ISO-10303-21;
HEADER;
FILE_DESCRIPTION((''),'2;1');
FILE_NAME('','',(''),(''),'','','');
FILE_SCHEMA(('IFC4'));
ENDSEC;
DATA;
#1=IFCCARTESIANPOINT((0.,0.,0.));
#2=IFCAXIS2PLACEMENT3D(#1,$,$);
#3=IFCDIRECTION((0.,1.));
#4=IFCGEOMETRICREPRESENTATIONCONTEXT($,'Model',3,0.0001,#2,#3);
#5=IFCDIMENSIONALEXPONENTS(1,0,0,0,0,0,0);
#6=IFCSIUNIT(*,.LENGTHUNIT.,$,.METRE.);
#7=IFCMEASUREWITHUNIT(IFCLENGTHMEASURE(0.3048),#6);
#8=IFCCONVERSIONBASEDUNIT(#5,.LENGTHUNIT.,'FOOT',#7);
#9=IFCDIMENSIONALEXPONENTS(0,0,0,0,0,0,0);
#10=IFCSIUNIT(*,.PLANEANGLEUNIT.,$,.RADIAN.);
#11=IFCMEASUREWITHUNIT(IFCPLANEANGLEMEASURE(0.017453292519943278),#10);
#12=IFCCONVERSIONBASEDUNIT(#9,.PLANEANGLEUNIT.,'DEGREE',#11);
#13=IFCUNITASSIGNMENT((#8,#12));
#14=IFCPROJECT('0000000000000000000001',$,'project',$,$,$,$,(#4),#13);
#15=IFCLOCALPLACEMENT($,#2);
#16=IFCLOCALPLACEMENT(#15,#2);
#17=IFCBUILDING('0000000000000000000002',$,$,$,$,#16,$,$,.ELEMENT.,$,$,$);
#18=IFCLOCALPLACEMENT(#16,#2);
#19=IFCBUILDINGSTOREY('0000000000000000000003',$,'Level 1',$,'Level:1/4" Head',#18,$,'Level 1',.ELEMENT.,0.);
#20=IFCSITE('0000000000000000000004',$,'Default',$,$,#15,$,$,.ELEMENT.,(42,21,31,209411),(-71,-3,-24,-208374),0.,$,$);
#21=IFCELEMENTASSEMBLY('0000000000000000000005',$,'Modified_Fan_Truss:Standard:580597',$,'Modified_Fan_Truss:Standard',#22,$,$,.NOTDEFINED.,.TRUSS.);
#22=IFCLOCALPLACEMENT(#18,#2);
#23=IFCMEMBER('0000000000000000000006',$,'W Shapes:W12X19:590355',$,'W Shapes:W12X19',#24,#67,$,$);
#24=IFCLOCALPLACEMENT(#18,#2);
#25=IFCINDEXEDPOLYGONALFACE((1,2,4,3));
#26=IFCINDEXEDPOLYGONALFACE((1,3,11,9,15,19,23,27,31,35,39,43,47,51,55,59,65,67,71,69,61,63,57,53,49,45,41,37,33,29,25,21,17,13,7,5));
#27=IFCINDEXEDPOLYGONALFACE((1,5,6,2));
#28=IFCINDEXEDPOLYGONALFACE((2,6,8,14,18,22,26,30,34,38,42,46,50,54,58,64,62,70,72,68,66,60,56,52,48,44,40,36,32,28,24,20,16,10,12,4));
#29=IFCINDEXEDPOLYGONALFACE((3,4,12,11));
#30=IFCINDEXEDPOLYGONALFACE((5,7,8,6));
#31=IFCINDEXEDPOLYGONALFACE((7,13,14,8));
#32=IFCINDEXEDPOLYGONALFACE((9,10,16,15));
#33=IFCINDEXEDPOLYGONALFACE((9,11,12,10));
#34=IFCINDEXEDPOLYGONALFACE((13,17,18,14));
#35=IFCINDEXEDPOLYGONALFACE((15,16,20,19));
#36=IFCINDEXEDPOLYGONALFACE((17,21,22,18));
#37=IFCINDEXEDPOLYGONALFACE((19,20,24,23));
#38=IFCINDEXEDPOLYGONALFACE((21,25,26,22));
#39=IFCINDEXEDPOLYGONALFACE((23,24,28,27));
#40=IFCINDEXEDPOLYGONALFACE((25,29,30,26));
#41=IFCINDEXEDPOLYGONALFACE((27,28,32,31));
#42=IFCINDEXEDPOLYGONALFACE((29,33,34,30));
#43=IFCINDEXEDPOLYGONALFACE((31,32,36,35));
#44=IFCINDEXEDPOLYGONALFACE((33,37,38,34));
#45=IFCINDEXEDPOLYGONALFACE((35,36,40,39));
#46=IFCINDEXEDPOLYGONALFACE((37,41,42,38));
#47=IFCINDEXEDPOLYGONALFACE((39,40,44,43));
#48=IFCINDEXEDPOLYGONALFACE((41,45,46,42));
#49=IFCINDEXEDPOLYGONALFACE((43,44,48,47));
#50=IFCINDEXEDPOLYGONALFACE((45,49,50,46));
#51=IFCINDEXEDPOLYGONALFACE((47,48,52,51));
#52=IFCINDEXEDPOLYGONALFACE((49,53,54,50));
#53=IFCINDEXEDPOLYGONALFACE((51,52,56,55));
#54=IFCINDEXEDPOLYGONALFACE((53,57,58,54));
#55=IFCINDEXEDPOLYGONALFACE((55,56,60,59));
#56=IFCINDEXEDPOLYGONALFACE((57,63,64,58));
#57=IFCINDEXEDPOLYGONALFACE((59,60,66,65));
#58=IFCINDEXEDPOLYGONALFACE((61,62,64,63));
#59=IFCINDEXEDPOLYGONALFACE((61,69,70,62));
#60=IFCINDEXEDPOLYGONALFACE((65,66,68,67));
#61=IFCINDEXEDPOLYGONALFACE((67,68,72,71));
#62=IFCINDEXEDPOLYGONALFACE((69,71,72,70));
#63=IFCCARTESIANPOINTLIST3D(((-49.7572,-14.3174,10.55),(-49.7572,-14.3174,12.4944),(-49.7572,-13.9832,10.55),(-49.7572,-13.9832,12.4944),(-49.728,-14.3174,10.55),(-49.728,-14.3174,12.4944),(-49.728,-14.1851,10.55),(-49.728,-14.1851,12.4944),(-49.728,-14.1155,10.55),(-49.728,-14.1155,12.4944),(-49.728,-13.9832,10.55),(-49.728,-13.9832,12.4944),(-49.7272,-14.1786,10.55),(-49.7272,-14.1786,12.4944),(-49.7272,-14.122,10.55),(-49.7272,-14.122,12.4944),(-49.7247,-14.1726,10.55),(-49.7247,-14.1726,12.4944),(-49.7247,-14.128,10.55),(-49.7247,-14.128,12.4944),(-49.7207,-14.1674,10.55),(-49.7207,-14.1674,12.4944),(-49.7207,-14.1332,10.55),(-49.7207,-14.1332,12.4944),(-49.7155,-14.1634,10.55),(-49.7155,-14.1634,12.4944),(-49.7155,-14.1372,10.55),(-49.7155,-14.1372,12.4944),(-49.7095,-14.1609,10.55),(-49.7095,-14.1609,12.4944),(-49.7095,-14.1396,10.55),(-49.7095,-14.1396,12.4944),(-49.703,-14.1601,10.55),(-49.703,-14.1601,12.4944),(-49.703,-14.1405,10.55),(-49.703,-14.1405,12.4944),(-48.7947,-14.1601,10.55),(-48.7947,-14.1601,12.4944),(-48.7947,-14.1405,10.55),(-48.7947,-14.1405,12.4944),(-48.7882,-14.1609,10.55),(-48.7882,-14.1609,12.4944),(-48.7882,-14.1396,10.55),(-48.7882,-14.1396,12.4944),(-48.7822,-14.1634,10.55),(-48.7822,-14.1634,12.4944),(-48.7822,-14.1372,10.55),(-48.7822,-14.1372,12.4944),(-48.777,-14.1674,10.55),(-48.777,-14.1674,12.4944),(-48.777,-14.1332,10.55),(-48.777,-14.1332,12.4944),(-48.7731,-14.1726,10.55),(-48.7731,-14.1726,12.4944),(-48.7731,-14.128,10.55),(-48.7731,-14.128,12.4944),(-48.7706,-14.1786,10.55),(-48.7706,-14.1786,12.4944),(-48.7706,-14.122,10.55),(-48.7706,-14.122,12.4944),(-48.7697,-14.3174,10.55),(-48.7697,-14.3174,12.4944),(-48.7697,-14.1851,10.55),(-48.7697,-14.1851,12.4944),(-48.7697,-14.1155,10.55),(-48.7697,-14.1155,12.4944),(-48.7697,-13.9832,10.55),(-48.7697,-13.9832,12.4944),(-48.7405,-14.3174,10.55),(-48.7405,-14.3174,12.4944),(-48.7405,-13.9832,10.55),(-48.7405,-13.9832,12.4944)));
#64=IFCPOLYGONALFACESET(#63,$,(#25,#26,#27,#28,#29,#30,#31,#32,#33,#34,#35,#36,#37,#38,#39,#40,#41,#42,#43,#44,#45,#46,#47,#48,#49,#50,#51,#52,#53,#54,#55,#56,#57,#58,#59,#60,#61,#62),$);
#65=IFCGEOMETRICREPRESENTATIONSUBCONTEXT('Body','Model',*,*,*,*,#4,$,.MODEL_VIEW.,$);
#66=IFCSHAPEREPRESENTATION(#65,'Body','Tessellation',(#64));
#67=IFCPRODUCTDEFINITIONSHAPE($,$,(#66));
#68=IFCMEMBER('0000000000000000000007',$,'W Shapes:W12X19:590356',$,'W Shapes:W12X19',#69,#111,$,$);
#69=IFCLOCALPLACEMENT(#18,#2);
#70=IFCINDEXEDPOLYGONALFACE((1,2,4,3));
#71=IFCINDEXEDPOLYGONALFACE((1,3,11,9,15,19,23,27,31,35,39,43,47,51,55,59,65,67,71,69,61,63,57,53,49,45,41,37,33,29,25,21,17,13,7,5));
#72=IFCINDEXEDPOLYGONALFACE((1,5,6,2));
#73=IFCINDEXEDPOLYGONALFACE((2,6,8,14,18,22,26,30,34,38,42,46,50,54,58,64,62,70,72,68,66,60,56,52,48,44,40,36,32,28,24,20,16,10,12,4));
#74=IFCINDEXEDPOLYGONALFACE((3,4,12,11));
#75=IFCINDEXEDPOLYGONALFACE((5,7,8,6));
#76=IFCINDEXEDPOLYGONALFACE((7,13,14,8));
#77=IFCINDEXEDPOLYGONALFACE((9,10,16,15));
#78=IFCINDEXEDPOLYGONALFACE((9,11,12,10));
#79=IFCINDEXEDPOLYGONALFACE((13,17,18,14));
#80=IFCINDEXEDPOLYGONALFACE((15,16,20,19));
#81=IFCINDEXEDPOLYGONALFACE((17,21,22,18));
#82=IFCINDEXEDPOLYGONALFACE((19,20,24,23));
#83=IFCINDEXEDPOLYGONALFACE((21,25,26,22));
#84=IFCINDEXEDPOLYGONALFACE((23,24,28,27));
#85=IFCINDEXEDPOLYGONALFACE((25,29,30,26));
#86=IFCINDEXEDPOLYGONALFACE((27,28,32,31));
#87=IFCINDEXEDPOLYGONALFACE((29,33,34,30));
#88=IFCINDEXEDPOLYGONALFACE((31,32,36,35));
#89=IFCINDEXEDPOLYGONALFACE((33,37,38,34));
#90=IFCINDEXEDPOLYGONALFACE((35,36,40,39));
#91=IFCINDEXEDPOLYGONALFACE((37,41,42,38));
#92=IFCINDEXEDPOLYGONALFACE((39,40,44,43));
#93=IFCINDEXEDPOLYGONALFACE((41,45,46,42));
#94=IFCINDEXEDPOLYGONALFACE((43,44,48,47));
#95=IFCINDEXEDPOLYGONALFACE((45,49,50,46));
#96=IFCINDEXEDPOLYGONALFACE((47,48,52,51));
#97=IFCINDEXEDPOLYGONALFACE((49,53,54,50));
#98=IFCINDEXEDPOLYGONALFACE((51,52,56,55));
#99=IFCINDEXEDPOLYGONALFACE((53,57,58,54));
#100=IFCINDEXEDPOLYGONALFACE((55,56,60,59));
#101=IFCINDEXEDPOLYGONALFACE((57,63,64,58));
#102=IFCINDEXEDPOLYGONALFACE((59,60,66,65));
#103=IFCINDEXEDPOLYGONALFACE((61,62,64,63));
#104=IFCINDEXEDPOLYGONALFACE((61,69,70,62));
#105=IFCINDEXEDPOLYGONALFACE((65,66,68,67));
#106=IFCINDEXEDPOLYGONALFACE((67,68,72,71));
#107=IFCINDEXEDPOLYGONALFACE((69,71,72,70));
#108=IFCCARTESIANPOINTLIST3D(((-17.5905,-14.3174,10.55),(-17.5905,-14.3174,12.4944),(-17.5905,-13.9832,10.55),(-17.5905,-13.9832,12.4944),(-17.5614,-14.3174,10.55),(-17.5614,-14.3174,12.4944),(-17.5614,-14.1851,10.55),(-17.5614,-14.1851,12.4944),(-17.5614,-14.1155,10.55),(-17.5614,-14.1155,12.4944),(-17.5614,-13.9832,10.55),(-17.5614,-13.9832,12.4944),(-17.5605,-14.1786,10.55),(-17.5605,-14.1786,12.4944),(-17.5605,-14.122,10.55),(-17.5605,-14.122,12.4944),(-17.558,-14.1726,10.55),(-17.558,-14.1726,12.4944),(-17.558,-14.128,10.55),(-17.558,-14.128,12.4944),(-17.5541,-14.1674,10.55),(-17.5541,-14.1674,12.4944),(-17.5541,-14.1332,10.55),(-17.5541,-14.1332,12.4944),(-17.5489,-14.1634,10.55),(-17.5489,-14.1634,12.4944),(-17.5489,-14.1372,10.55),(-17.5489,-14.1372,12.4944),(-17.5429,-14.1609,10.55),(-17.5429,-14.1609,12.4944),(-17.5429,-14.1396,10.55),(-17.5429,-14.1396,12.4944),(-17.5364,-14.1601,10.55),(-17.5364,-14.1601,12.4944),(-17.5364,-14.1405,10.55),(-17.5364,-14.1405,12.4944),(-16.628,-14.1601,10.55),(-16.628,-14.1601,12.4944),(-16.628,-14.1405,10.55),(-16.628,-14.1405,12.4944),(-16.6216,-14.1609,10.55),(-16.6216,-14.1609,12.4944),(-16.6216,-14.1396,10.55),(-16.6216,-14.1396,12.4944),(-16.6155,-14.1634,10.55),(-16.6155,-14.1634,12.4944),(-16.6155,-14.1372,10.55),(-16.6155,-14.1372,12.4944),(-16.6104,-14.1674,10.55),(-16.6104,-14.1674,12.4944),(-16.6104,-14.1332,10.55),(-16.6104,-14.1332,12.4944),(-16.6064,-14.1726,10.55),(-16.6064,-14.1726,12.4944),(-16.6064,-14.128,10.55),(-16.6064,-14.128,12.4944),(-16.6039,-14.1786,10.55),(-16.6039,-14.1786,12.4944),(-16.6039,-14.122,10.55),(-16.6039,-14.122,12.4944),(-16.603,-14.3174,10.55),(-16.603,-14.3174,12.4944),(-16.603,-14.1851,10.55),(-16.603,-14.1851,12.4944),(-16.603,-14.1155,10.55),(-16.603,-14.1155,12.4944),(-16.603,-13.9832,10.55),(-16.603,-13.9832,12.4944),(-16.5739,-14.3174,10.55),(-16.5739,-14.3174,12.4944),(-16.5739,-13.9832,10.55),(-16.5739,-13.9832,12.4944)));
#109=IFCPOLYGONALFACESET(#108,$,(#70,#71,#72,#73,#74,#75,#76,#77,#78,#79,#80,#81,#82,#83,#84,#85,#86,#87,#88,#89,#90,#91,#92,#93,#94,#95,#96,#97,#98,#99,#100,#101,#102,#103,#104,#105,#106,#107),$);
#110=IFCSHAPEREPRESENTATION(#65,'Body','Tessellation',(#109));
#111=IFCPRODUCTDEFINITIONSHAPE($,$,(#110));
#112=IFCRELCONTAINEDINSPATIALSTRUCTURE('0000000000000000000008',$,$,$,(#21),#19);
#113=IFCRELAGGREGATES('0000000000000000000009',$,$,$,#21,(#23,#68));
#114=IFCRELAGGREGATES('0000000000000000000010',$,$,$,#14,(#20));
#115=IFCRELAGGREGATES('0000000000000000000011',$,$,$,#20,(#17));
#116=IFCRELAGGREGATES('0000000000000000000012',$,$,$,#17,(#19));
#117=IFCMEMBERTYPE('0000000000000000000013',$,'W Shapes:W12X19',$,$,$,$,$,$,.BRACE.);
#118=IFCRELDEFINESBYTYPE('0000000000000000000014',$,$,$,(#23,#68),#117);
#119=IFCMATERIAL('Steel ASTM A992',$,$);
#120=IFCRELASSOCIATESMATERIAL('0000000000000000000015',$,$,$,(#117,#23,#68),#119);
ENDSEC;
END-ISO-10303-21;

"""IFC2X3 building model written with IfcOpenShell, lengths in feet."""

from ifc_helpers import new_model, entity, si_unit, converted_unit, direction, frame, frame_2d, origin, place, context, subcontext, project, spatial, polyline, circle_curve, parameter, trimmed, segment, composite_curve, outline, extrude, source, transform, mapped, material, type_object, type_shapes, element, aggregate, save


model = new_model("IFC2X3")

# Units and contexts
model_context = context("Model", 3, precision=0.0001, world=origin(), true_north=direction((0.0, 1.0)))
body_context = subcontext(model_context, "Body", "Model", "MODEL_VIEW")
ifc_project = project(units=[converted_unit("LENGTHUNIT", "FOOT", entity("IfcLengthMeasure", 0.3048), si_unit("LENGTHUNIT", "METRE"), dimensions=[1, 0, 0, 0, 0, 0, 0]), converted_unit("PLANEANGLEUNIT", "DEGREE", entity("IfcPlaneAngleMeasure", 0.017453292519943278), si_unit("PLANEANGLEUNIT", "RADIAN"), dimensions=[0, 0, 0, 0, 0, 0, 0])], contexts=[model_context])

# Site, building, storey
site_placement = place(None, origin())
site = spatial("IfcSite", under=ifc_project, at=site_placement, Name="Default", CompositionType="ELEMENT", RefLatitude=(42, 21, 31, 209411), RefLongitude=(-71, -3, -24, -208374), RefElevation=0.0)
building_placement = place(site_placement, origin())
building = spatial("IfcBuilding", under=site, at=building_placement, CompositionType="ELEMENT")
storey_placement = place(building_placement, origin())
storey = spatial("IfcBuildingStorey", under=building, at=storey_placement, Name="Level 1", ObjectType="Level:1/4\" Head", LongName="Level 1", CompositionType="ELEMENT", Elevation=0.0)

# Element assembly, members
assembly_placement = place(storey_placement, origin())
assembly = element("IfcElementAssembly", 1, at=assembly_placement, inside=storey, Name="Modified_Fan_Truss:Standard:580597", ObjectType="Modified_Fan_Truss:Standard", AssemblyPlace="NOTDEFINED", PredefinedType="TRUSS")
ifc_material = material(Name="Steel ASTM A992")
member_type_1 = type_object("IfcMemberType", Name="W Shapes:W12X19", PredefinedType="BRACE", material=ifc_material)
shared_shape_1 = source(origin(), body_context, "Body", "SweptSolid", [
    extrude(outline(composite_curve([segment(polyline([(-0.1671, -0.4792), (-0.1671, -0.5083)]), True, "CONTINUOUS"), segment(polyline([(-0.1671, -0.5083), (0.1671, -0.5083)]), True, "CONTINUOUS"), segment(polyline([(0.1671, -0.5083), (0.1671, -0.4792)]), True, "CONTINUOUS"), segment(polyline([(0.1671, -0.4792), (0.0348, -0.4792)]), True, "CONTINUOUS"), segment(trimmed(circle_curve(frame_2d((0.0348, -0.4542), x_axis=(0.0, -1.0)), 0.025), [parameter(270.0)], [parameter(360.0)], True, "PARAMETER"), False, "CONTINUOUS"), segment(polyline([(0.0098, -0.4542), (0.0098, 0.4542)]), True, "CONTINUOUS"), segment(trimmed(circle_curve(frame_2d((0.0348, 0.4542), x_axis=(-1.0, 0.0)), 0.025), [parameter(270.0)], [parameter(360.0)], True, "PARAMETER"), False, "CONTINUOUS"), segment(polyline([(0.0348, 0.4792), (0.1671, 0.4792)]), True, "CONTINUOUS"), segment(polyline([(0.1671, 0.4792), (0.1671, 0.5083)]), True, "CONTINUOUS"), segment(polyline([(0.1671, 0.5083), (-0.1671, 0.5083)]), True, "CONTINUOUS"), segment(polyline([(-0.1671, 0.5083), (-0.1671, 0.4792)]), True, "CONTINUOUS"), segment(polyline([(-0.1671, 0.4792), (-0.0348, 0.4792)]), True, "CONTINUOUS"), segment(trimmed(circle_curve(frame_2d((-0.0348, 0.4542), x_axis=(0.0, 1.0)), 0.025), [parameter(270.0)], [parameter(0.0)], True, "PARAMETER"), False, "CONTINUOUS"), segment(polyline([(-0.0098, 0.4542), (-0.0098, -0.4542)]), True, "CONTINUOUS"), segment(trimmed(circle_curve(frame_2d((-0.0348, -0.4542), x_axis=(1.0, 0.0)), 0.025), [parameter(270.0)], [parameter(0.0)], True, "PARAMETER"), False, "CONTINUOUS"), segment(polyline([(-0.0348, -0.4792), (-0.1671, -0.4792)]), True, "CONTINUOUS")], self_intersect=False)), frame((-1.0993, 0.0, 0.0), z_axis=(-1.0, 0.0, 0.0), x_axis=(0.0, -1.0, 0.0)), (0.0, 0.0, -1.0), 1.9444),
])
type_shapes(member_type_1, [shared_shape_1])
member_1_placement = place(assembly_placement, frame((-49.2489, -14.1503, 11.6493), z_axis=(1.0, 0.0, 0.0), x_axis=(0.0, 0.0, 1.0)))
member_1 = element("IfcMember", 2, at=member_1_placement, type_object=member_type_1, material=ifc_material, Name="W Shapes:W12X19:590355", ObjectType="W Shapes:W12X19", context=body_context, shape_type="MappedRepresentation", body=[
    mapped(shared_shape_1, transform((0.0, 0.0, 0.0), scale=1.0)),
])
member_2_placement = place(assembly_placement, frame((-17.0822, -14.1503, 11.6493), z_axis=(1.0, 0.0, 0.0), x_axis=(0.0, 0.0, 1.0)))
member_2 = element("IfcMember", 3, at=member_2_placement, type_object=member_type_1, material=ifc_material, Name="W Shapes:W12X19:590356", ObjectType="W Shapes:W12X19", context=body_context, shape_type="MappedRepresentation", body=[
    mapped(shared_shape_1, transform((0.0, 0.0, 0.0), scale=1.0)),
])
aggregate(assembly, [member_1, member_2])

save(model, "model.ifc")
